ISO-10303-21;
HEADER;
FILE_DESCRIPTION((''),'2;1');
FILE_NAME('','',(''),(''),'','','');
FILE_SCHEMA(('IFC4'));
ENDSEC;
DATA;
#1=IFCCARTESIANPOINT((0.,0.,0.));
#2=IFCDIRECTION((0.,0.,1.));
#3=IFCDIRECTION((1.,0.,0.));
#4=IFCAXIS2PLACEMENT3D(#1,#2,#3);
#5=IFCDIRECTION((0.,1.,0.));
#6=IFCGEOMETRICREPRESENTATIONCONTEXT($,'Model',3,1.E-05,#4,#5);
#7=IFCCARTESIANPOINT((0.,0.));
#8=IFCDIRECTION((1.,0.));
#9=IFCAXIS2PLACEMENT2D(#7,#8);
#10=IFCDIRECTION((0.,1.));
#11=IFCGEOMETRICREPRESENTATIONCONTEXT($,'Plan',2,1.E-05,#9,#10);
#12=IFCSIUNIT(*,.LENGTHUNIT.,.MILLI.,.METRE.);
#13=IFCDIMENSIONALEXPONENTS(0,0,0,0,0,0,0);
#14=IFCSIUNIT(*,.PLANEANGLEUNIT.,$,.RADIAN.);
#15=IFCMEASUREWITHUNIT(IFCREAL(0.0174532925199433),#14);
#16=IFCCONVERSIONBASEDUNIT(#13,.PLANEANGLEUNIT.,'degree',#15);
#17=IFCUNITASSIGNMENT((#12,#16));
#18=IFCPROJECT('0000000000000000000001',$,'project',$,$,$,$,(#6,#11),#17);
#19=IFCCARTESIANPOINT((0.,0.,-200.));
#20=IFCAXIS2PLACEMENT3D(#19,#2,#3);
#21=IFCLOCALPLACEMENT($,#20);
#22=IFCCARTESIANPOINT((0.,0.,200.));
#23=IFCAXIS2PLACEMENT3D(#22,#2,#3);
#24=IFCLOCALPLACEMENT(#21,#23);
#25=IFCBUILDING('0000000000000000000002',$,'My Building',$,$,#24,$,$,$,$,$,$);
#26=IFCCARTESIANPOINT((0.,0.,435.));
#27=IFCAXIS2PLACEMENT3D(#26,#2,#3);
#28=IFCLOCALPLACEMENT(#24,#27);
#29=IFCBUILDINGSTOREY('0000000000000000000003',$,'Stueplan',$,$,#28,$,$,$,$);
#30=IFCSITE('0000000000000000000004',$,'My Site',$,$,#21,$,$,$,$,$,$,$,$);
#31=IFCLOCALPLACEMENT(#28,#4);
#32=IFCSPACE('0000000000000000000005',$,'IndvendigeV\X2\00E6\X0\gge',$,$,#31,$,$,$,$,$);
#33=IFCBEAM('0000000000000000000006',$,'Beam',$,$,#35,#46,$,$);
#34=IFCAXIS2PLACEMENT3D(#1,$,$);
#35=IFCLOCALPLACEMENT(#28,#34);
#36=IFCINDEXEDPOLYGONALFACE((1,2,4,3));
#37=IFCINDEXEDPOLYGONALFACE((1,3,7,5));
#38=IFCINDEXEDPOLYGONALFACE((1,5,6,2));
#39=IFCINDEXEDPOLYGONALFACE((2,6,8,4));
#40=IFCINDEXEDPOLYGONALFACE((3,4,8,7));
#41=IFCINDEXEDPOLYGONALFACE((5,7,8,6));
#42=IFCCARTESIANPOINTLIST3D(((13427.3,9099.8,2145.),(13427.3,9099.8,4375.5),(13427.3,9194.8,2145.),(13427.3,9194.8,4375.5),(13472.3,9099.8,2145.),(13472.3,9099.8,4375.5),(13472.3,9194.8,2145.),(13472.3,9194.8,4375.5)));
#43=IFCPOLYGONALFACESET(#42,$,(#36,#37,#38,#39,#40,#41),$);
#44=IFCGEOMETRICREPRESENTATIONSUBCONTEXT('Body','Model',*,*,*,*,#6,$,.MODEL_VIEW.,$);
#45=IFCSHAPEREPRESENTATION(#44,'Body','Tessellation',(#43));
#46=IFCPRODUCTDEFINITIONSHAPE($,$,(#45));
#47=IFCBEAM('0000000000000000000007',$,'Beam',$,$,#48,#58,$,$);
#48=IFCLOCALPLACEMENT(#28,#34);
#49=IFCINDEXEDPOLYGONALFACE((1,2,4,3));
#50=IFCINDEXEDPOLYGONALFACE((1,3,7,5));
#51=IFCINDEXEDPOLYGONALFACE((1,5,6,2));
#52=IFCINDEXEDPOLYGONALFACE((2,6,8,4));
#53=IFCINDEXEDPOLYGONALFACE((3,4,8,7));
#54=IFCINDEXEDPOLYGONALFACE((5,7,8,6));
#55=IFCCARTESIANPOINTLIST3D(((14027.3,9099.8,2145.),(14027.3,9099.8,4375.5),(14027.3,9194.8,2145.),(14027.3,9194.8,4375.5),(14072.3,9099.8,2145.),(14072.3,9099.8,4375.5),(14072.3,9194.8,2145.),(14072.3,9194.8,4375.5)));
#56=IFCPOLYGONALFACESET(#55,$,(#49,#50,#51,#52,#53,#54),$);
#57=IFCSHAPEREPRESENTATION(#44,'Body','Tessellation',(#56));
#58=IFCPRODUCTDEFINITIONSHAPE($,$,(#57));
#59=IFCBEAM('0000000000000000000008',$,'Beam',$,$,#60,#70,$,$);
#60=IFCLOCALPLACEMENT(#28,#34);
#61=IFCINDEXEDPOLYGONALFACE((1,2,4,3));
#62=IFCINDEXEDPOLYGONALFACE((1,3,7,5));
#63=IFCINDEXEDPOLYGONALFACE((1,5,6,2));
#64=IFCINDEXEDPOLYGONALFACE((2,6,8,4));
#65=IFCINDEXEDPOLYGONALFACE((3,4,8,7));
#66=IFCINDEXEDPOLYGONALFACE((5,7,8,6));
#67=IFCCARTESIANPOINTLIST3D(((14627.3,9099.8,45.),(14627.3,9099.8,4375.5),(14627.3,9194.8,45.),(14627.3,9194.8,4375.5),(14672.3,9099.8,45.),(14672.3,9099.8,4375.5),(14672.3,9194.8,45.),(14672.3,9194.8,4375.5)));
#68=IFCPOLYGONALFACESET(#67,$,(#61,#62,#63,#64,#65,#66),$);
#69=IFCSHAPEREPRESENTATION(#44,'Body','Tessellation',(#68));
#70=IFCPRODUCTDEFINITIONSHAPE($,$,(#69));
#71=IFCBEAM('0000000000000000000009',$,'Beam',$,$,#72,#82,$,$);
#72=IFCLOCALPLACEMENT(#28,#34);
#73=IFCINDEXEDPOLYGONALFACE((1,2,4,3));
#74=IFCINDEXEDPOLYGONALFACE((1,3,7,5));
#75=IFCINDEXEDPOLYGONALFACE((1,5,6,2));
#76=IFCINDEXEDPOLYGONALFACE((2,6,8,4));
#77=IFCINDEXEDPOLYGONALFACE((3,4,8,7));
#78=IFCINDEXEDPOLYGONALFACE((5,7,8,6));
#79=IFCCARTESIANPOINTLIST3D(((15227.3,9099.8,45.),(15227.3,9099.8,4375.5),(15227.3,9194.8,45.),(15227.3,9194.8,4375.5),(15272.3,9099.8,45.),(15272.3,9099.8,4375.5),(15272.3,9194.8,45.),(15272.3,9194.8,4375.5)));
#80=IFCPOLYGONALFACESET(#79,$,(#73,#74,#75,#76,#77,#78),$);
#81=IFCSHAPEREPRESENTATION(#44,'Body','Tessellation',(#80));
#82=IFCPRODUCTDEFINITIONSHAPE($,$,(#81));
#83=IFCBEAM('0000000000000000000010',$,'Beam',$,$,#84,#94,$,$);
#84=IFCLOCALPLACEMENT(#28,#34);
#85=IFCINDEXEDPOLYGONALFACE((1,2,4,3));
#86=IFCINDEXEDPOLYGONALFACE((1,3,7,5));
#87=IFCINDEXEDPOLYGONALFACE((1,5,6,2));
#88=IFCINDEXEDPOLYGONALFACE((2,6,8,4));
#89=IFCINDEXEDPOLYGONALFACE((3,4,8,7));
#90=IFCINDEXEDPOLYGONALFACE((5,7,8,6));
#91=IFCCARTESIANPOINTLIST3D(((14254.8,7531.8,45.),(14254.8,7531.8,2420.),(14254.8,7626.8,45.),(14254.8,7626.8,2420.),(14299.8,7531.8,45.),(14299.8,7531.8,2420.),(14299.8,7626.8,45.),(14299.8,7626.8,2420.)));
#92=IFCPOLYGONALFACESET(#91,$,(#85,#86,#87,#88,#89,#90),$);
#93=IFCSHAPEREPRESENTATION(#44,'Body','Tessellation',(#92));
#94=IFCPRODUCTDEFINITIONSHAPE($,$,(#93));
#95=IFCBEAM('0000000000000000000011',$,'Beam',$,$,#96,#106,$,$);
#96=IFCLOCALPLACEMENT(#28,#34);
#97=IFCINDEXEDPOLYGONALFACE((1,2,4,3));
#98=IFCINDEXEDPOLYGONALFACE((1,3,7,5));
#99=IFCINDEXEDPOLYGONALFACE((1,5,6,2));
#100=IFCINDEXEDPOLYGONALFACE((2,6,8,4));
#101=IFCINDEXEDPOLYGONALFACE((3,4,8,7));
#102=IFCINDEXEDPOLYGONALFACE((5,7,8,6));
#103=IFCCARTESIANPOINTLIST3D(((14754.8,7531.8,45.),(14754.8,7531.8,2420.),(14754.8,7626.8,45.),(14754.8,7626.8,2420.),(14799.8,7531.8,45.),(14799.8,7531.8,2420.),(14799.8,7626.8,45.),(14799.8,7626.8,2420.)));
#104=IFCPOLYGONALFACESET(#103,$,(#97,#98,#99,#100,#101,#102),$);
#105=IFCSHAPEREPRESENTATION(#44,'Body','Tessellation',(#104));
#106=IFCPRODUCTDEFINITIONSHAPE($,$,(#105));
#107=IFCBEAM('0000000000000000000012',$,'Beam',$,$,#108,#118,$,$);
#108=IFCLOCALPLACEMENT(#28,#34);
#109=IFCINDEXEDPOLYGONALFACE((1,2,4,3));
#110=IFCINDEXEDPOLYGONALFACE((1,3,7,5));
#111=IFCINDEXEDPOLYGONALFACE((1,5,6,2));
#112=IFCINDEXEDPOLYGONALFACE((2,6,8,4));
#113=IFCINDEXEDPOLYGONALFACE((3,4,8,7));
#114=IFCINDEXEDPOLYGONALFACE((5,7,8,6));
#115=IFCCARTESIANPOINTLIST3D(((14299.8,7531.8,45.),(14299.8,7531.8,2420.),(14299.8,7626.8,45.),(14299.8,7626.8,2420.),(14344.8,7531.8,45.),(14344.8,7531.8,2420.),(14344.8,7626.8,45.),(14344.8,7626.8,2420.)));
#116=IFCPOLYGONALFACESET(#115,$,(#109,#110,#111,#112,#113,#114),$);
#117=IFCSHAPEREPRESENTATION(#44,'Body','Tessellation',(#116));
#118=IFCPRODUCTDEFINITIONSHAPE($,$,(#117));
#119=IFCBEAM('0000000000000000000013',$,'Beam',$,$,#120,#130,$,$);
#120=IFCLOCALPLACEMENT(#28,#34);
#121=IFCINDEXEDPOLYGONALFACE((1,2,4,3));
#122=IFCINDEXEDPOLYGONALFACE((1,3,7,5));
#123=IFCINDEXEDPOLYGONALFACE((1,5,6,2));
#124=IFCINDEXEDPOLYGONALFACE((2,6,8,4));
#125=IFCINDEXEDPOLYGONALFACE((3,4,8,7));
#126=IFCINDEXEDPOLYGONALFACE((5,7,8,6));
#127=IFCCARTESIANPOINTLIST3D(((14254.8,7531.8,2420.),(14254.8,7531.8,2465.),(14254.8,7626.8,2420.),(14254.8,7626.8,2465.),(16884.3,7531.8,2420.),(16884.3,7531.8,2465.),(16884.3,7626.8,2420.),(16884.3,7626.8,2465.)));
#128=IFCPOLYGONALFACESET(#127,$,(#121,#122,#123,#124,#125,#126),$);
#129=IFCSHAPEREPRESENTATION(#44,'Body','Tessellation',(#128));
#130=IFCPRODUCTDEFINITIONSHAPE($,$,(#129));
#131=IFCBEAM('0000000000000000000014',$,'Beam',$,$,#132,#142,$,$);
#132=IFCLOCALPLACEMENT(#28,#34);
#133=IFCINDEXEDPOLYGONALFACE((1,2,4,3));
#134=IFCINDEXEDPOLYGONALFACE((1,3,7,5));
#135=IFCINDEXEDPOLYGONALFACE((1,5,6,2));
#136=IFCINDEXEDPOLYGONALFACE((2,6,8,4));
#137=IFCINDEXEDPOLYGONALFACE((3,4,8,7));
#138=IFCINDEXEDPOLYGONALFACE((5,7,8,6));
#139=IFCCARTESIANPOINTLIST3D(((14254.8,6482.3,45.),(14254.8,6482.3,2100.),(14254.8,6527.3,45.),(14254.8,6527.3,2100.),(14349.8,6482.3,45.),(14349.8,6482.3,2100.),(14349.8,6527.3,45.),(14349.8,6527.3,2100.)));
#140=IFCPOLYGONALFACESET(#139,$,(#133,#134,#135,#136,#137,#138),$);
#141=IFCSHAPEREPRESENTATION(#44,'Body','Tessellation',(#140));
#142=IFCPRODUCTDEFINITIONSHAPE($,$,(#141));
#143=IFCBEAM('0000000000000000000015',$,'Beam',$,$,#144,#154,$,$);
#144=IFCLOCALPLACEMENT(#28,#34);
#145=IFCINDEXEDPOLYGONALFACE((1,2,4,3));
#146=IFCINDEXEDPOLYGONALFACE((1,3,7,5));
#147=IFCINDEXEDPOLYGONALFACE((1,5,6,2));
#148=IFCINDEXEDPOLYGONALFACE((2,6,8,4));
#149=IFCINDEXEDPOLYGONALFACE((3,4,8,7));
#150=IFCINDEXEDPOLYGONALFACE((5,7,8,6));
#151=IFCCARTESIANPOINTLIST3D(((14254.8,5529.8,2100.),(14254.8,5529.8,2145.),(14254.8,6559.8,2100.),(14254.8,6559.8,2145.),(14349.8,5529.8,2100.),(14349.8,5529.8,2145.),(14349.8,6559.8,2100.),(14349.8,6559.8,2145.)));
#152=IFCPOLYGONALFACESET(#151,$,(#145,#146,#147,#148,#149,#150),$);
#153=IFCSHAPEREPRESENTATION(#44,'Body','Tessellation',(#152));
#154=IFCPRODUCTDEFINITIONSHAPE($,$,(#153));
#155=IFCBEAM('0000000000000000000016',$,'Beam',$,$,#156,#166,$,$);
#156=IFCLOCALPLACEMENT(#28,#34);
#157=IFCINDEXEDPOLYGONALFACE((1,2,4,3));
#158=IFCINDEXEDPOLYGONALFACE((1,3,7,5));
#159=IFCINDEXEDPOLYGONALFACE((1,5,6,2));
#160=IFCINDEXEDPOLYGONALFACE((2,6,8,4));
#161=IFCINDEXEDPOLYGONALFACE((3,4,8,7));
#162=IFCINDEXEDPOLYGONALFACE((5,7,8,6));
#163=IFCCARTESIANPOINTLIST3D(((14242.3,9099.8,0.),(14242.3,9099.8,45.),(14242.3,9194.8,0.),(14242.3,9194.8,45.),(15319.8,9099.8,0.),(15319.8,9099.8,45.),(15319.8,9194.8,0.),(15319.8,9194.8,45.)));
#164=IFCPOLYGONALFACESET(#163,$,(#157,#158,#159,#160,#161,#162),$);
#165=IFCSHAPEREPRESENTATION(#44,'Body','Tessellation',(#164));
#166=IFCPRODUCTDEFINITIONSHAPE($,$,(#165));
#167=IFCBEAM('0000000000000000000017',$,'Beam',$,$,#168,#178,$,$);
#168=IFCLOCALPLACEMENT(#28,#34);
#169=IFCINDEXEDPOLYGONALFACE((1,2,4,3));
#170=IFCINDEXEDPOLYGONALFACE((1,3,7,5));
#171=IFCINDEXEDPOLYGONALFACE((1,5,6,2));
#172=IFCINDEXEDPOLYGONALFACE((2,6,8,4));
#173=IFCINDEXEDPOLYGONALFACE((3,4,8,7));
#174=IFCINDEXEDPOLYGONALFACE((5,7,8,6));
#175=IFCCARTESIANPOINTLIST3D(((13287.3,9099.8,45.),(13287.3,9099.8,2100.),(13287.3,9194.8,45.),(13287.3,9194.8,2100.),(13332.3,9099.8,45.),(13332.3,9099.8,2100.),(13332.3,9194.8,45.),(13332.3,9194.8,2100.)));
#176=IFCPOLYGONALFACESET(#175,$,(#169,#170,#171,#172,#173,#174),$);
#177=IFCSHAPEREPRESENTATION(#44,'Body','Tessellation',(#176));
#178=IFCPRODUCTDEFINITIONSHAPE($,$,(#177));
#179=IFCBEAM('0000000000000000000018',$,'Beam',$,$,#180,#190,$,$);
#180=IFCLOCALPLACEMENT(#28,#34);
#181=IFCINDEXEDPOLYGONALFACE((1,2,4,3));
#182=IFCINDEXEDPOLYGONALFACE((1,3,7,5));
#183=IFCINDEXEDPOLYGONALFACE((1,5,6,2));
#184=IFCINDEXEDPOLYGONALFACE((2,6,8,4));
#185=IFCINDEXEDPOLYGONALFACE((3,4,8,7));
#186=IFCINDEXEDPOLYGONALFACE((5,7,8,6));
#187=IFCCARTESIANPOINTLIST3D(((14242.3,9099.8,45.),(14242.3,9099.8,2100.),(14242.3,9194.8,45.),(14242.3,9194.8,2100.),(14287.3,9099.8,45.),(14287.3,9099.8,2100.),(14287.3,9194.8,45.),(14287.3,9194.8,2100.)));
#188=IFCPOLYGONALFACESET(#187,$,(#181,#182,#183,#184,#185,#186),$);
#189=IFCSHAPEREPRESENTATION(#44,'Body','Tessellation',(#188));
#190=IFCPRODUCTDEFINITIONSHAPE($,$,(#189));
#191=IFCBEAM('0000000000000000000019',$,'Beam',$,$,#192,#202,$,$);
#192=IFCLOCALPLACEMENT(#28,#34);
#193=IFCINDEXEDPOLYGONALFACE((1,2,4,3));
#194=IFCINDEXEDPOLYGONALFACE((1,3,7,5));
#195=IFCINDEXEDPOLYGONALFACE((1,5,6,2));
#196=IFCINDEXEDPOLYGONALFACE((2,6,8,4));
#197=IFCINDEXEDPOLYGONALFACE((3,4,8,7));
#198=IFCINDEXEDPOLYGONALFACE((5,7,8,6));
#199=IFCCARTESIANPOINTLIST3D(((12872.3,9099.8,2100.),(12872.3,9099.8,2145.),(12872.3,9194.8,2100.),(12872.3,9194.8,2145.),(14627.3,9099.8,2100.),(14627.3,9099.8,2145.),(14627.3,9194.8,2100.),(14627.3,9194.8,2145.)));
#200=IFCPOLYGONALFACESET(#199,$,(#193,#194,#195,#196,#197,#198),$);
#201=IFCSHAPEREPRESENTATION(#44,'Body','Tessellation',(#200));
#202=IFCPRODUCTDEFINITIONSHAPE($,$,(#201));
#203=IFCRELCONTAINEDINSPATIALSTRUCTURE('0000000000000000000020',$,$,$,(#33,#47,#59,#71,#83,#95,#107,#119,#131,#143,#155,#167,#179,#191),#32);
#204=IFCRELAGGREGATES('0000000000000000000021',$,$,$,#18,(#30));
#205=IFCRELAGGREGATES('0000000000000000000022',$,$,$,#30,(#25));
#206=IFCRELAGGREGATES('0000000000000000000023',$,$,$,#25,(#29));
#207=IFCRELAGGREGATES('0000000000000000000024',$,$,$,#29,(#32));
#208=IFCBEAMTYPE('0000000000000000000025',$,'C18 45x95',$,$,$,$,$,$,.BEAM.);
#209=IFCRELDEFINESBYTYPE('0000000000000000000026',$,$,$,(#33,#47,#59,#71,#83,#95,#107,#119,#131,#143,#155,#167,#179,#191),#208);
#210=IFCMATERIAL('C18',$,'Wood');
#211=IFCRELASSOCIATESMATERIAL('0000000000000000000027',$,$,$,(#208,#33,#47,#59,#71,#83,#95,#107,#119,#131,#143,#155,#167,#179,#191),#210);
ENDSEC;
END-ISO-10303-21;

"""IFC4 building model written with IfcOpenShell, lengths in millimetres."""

from ifc_helpers import new_model, entity, si_unit, converted_unit, direction, frame, origin_with_axes, origin_2d_with_axis, place, context, subcontext, project, spatial, rectangle, extrude, material, material_profile, profile_set, profile_usage, type_object, element, save


model = new_model("IFC4")

# Units and contexts
model_context = context("Model", 3, precision=1e-05, world=origin_with_axes(), true_north=direction((0.0, 1.0, 0.0)))
plan_context = context("Plan", 2, precision=1e-05, world=origin_2d_with_axis(), true_north=direction((0.0, 1.0)))
body_context_1 = subcontext(model_context, "Body", "Model", "MODEL_VIEW")
ifc_project = project(units=[si_unit("LENGTHUNIT", "METRE", prefix="MILLI"), converted_unit("PLANEANGLEUNIT", "degree", entity("IfcReal", 0.0174532925199433), si_unit("PLANEANGLEUNIT", "RADIAN"), dimensions=[0, 0, 0, 0, 0, 0, 0])], contexts=[model_context, plan_context])

# Site, building, storey
site_placement = place(None, frame((0.0, 0.0, -200.0), z_axis=(0.0, 0.0, 1.0), x_axis=(1.0, 0.0, 0.0)))
site = spatial("IfcSite", under=ifc_project, at=site_placement, Name="My Site")
building_placement = place(site_placement, frame((0.0, 0.0, 200.0), z_axis=(0.0, 0.0, 1.0), x_axis=(1.0, 0.0, 0.0)))
building = spatial("IfcBuilding", under=site, at=building_placement, Name="My Building")
storey_placement = place(building_placement, frame((0.0, 0.0, 435.0), z_axis=(0.0, 0.0, 1.0), x_axis=(1.0, 0.0, 0.0)))
storey = spatial("IfcBuildingStorey", under=building, at=storey_placement, Name="Stueplan")

# Shared definitions
ifc_material = material(Name="C18", Category="Wood")

# Shared definitions
space_1_placement = place(storey_placement, frame((0.0, 0.0, 0.0), z_axis=(0.0, 0.0, 1.0), x_axis=(1.0, 0.0, 0.0)))
space_1 = spatial("IfcSpace", under=storey, at=space_1_placement, Name="IndvendigeVægge")

# Beams
ifc_material_profile_1 = material_profile(ifc_material, rectangle(XDim=45.0, YDim=95.0))
ifc_profile_set_1 = profile_set([ifc_material_profile_1], Name="woodStructural")
beam_type_1 = type_object("IfcBeamType", Name="C18 45x95", PredefinedType="BEAM", material=ifc_profile_set_1)
ifc_profile_usage_1 = profile_usage(ifc_profile_set_1)
beam_1_placement = place(space_1_placement, frame((13449.8, 9147.3, 2145.0), z_axis=(0.0, 0.0, 1.0), x_axis=(-1.0, 0.0, 0.0)))
element("IfcBeam", 1, at=beam_1_placement, inside=space_1, type_object=beam_type_1, material=ifc_profile_usage_1, Name="Beam", context=body_context_1, shape_type="SweptSolid", body=[
    extrude(rectangle(XDim=45.0, YDim=95.0), origin_with_axes(), (0.0, 0.0, 1.0), 2230.5),
])
ifc_profile_usage_2 = profile_usage(ifc_profile_set_1)
beam_2_placement = place(space_1_placement, frame((14049.8, 9147.3, 2145.0), z_axis=(0.0, 0.0, 1.0), x_axis=(-1.0, 0.0, 0.0)))
element("IfcBeam", 2, at=beam_2_placement, inside=space_1, type_object=beam_type_1, material=ifc_profile_usage_2, Name="Beam", context=body_context_1, shape_type="SweptSolid", body=[
    extrude(rectangle(XDim=45.0, YDim=95.0), origin_with_axes(), (0.0, 0.0, 1.0), 2230.5),
])
ifc_profile_usage_3 = profile_usage(ifc_profile_set_1)
beam_3_placement = place(space_1_placement, frame((14649.8, 9147.3, 45.0), z_axis=(0.0, 0.0, 1.0), x_axis=(-1.0, 0.0, 0.0)))
element("IfcBeam", 3, at=beam_3_placement, inside=space_1, type_object=beam_type_1, material=ifc_profile_usage_3, Name="Beam", context=body_context_1, shape_type="SweptSolid", body=[
    extrude(rectangle(XDim=45.0, YDim=95.0), origin_with_axes(), (0.0, 0.0, 1.0), 4330.5),
])
ifc_profile_usage_4 = profile_usage(ifc_profile_set_1)
beam_4_placement = place(space_1_placement, frame((15249.8, 9147.3, 45.0), z_axis=(0.0, 0.0, 1.0), x_axis=(-1.0, 0.0, 0.0)))
element("IfcBeam", 4, at=beam_4_placement, inside=space_1, type_object=beam_type_1, material=ifc_profile_usage_4, Name="Beam", context=body_context_1, shape_type="SweptSolid", body=[
    extrude(rectangle(XDim=45.0, YDim=95.0), origin_with_axes(), (0.0, 0.0, 1.0), 4330.5),
])
ifc_profile_usage_5 = profile_usage(ifc_profile_set_1)
beam_5_placement = place(space_1_placement, frame((14277.3, 7579.3, 45.0), z_axis=(0.0, 0.0, 1.0), x_axis=(1.0, 0.0, 0.0)))
element("IfcBeam", 5, at=beam_5_placement, inside=space_1, type_object=beam_type_1, material=ifc_profile_usage_5, Name="Beam", context=body_context_1, shape_type="SweptSolid", body=[
    extrude(rectangle(XDim=45.0, YDim=95.0), origin_with_axes(), (0.0, 0.0, 1.0), 2375.0),
])
ifc_profile_usage_6 = profile_usage(ifc_profile_set_1)
beam_6_placement = place(space_1_placement, frame((14777.3, 7579.3, 45.0), z_axis=(0.0, 0.0, 1.0), x_axis=(1.0, 0.0, 0.0)))
element("IfcBeam", 6, at=beam_6_placement, inside=space_1, type_object=beam_type_1, material=ifc_profile_usage_6, Name="Beam", context=body_context_1, shape_type="SweptSolid", body=[
    extrude(rectangle(XDim=45.0, YDim=95.0), origin_with_axes(), (0.0, 0.0, 1.0), 2375.0),
])
ifc_profile_usage_7 = profile_usage(ifc_profile_set_1)
beam_7_placement = place(space_1_placement, frame((14322.3, 7579.3, 45.0), z_axis=(0.0, 0.0, 1.0), x_axis=(1.0, 0.0, 0.0)))
element("IfcBeam", 7, at=beam_7_placement, inside=space_1, type_object=beam_type_1, material=ifc_profile_usage_7, Name="Beam", context=body_context_1, shape_type="SweptSolid", body=[
    extrude(rectangle(XDim=45.0, YDim=95.0), origin_with_axes(), (0.0, 0.0, 1.0), 2375.0),
])
ifc_profile_usage_8 = profile_usage(ifc_profile_set_1, cardinal=5)
beam_8_placement = place(space_1_placement, frame((14254.8, 7579.3, 2442.5), z_axis=(1.0, 0.0, 0.0), x_axis=(0.0, 0.0, 1.0)))
element("IfcBeam", 8, at=beam_8_placement, inside=space_1, type_object=beam_type_1, material=ifc_profile_usage_8, Name="Beam", context=body_context_1, shape_type="SweptSolid", body=[
    extrude(rectangle(XDim=45.0, YDim=95.0), origin_with_axes(), (0.0, 0.0, 1.0), 2629.5),
])
ifc_profile_usage_9 = profile_usage(ifc_profile_set_1)
beam_9_placement = place(space_1_placement, frame((14302.3, 6504.8, 45.0), z_axis=(0.0, 0.0, 1.0), x_axis=(0.0, -1.0, 0.0)))
element("IfcBeam", 9, at=beam_9_placement, inside=space_1, type_object=beam_type_1, material=ifc_profile_usage_9, Name="Beam", context=body_context_1, shape_type="SweptSolid", body=[
    extrude(rectangle(XDim=45.0, YDim=95.0), origin_with_axes(), (0.0, 0.0, 1.0), 2055.0),
])
ifc_profile_usage_10 = profile_usage(ifc_profile_set_1, cardinal=5)
beam_10_placement = place(space_1_placement, frame((14302.3, 6559.8, 2122.5), z_axis=(0.0, -1.0, 0.0), x_axis=(0.0, 0.0, 1.0)))
element("IfcBeam", 10, at=beam_10_placement, inside=space_1, type_object=beam_type_1, material=ifc_profile_usage_10, Name="Beam", context=body_context_1, shape_type="SweptSolid", body=[
    extrude(rectangle(XDim=45.0, YDim=95.0), origin_with_axes(), (0.0, 0.0, 1.0), 1030.0),
])
ifc_profile_usage_11 = profile_usage(ifc_profile_set_1, cardinal=5)
beam_11_placement = place(space_1_placement, frame((14242.3, 9147.3, 22.5), z_axis=(1.0, 0.0, 0.0), x_axis=(0.0, 0.0, 1.0)))
element("IfcBeam", 11, at=beam_11_placement, inside=space_1, type_object=beam_type_1, material=ifc_profile_usage_11, Name="Beam", context=body_context_1, shape_type="SweptSolid", body=[
    extrude(rectangle(XDim=45.0, YDim=95.0), origin_with_axes(), (0.0, 0.0, 1.0), 1077.5),
])
ifc_profile_usage_12 = profile_usage(ifc_profile_set_1)
beam_12_placement = place(space_1_placement, frame((13309.8, 9147.3, 45.0), z_axis=(0.0, 0.0, 1.0), x_axis=(1.0, 0.0, 0.0)))
element("IfcBeam", 12, at=beam_12_placement, inside=space_1, type_object=beam_type_1, material=ifc_profile_usage_12, Name="Beam", context=body_context_1, shape_type="SweptSolid", body=[
    extrude(rectangle(XDim=45.0, YDim=95.0), origin_with_axes(), (0.0, 0.0, 1.0), 2055.0),
])
ifc_profile_usage_13 = profile_usage(ifc_profile_set_1)
beam_13_placement = place(space_1_placement, frame((14264.8, 9147.3, 45.0), z_axis=(0.0, 0.0, 1.0), x_axis=(1.0, 0.0, 0.0)))
element("IfcBeam", 13, at=beam_13_placement, inside=space_1, type_object=beam_type_1, material=ifc_profile_usage_13, Name="Beam", context=body_context_1, shape_type="SweptSolid", body=[
    extrude(rectangle(XDim=45.0, YDim=95.0), origin_with_axes(), (0.0, 0.0, 1.0), 2055.0),
])
ifc_profile_usage_14 = profile_usage(ifc_profile_set_1, cardinal=5)
beam_14_placement = place(space_1_placement, frame((12872.3, 9147.3, 2122.5), z_axis=(1.0, 0.0, 0.0), x_axis=(0.0, 0.0, 1.0)))
element("IfcBeam", 14, at=beam_14_placement, inside=space_1, type_object=beam_type_1, material=ifc_profile_usage_14, Name="Beam", context=body_context_1, shape_type="SweptSolid", body=[
    extrude(rectangle(XDim=45.0, YDim=95.0), origin_with_axes(), (0.0, 0.0, 1.0), 1755.0),
])

save(model, "model.ifc")
